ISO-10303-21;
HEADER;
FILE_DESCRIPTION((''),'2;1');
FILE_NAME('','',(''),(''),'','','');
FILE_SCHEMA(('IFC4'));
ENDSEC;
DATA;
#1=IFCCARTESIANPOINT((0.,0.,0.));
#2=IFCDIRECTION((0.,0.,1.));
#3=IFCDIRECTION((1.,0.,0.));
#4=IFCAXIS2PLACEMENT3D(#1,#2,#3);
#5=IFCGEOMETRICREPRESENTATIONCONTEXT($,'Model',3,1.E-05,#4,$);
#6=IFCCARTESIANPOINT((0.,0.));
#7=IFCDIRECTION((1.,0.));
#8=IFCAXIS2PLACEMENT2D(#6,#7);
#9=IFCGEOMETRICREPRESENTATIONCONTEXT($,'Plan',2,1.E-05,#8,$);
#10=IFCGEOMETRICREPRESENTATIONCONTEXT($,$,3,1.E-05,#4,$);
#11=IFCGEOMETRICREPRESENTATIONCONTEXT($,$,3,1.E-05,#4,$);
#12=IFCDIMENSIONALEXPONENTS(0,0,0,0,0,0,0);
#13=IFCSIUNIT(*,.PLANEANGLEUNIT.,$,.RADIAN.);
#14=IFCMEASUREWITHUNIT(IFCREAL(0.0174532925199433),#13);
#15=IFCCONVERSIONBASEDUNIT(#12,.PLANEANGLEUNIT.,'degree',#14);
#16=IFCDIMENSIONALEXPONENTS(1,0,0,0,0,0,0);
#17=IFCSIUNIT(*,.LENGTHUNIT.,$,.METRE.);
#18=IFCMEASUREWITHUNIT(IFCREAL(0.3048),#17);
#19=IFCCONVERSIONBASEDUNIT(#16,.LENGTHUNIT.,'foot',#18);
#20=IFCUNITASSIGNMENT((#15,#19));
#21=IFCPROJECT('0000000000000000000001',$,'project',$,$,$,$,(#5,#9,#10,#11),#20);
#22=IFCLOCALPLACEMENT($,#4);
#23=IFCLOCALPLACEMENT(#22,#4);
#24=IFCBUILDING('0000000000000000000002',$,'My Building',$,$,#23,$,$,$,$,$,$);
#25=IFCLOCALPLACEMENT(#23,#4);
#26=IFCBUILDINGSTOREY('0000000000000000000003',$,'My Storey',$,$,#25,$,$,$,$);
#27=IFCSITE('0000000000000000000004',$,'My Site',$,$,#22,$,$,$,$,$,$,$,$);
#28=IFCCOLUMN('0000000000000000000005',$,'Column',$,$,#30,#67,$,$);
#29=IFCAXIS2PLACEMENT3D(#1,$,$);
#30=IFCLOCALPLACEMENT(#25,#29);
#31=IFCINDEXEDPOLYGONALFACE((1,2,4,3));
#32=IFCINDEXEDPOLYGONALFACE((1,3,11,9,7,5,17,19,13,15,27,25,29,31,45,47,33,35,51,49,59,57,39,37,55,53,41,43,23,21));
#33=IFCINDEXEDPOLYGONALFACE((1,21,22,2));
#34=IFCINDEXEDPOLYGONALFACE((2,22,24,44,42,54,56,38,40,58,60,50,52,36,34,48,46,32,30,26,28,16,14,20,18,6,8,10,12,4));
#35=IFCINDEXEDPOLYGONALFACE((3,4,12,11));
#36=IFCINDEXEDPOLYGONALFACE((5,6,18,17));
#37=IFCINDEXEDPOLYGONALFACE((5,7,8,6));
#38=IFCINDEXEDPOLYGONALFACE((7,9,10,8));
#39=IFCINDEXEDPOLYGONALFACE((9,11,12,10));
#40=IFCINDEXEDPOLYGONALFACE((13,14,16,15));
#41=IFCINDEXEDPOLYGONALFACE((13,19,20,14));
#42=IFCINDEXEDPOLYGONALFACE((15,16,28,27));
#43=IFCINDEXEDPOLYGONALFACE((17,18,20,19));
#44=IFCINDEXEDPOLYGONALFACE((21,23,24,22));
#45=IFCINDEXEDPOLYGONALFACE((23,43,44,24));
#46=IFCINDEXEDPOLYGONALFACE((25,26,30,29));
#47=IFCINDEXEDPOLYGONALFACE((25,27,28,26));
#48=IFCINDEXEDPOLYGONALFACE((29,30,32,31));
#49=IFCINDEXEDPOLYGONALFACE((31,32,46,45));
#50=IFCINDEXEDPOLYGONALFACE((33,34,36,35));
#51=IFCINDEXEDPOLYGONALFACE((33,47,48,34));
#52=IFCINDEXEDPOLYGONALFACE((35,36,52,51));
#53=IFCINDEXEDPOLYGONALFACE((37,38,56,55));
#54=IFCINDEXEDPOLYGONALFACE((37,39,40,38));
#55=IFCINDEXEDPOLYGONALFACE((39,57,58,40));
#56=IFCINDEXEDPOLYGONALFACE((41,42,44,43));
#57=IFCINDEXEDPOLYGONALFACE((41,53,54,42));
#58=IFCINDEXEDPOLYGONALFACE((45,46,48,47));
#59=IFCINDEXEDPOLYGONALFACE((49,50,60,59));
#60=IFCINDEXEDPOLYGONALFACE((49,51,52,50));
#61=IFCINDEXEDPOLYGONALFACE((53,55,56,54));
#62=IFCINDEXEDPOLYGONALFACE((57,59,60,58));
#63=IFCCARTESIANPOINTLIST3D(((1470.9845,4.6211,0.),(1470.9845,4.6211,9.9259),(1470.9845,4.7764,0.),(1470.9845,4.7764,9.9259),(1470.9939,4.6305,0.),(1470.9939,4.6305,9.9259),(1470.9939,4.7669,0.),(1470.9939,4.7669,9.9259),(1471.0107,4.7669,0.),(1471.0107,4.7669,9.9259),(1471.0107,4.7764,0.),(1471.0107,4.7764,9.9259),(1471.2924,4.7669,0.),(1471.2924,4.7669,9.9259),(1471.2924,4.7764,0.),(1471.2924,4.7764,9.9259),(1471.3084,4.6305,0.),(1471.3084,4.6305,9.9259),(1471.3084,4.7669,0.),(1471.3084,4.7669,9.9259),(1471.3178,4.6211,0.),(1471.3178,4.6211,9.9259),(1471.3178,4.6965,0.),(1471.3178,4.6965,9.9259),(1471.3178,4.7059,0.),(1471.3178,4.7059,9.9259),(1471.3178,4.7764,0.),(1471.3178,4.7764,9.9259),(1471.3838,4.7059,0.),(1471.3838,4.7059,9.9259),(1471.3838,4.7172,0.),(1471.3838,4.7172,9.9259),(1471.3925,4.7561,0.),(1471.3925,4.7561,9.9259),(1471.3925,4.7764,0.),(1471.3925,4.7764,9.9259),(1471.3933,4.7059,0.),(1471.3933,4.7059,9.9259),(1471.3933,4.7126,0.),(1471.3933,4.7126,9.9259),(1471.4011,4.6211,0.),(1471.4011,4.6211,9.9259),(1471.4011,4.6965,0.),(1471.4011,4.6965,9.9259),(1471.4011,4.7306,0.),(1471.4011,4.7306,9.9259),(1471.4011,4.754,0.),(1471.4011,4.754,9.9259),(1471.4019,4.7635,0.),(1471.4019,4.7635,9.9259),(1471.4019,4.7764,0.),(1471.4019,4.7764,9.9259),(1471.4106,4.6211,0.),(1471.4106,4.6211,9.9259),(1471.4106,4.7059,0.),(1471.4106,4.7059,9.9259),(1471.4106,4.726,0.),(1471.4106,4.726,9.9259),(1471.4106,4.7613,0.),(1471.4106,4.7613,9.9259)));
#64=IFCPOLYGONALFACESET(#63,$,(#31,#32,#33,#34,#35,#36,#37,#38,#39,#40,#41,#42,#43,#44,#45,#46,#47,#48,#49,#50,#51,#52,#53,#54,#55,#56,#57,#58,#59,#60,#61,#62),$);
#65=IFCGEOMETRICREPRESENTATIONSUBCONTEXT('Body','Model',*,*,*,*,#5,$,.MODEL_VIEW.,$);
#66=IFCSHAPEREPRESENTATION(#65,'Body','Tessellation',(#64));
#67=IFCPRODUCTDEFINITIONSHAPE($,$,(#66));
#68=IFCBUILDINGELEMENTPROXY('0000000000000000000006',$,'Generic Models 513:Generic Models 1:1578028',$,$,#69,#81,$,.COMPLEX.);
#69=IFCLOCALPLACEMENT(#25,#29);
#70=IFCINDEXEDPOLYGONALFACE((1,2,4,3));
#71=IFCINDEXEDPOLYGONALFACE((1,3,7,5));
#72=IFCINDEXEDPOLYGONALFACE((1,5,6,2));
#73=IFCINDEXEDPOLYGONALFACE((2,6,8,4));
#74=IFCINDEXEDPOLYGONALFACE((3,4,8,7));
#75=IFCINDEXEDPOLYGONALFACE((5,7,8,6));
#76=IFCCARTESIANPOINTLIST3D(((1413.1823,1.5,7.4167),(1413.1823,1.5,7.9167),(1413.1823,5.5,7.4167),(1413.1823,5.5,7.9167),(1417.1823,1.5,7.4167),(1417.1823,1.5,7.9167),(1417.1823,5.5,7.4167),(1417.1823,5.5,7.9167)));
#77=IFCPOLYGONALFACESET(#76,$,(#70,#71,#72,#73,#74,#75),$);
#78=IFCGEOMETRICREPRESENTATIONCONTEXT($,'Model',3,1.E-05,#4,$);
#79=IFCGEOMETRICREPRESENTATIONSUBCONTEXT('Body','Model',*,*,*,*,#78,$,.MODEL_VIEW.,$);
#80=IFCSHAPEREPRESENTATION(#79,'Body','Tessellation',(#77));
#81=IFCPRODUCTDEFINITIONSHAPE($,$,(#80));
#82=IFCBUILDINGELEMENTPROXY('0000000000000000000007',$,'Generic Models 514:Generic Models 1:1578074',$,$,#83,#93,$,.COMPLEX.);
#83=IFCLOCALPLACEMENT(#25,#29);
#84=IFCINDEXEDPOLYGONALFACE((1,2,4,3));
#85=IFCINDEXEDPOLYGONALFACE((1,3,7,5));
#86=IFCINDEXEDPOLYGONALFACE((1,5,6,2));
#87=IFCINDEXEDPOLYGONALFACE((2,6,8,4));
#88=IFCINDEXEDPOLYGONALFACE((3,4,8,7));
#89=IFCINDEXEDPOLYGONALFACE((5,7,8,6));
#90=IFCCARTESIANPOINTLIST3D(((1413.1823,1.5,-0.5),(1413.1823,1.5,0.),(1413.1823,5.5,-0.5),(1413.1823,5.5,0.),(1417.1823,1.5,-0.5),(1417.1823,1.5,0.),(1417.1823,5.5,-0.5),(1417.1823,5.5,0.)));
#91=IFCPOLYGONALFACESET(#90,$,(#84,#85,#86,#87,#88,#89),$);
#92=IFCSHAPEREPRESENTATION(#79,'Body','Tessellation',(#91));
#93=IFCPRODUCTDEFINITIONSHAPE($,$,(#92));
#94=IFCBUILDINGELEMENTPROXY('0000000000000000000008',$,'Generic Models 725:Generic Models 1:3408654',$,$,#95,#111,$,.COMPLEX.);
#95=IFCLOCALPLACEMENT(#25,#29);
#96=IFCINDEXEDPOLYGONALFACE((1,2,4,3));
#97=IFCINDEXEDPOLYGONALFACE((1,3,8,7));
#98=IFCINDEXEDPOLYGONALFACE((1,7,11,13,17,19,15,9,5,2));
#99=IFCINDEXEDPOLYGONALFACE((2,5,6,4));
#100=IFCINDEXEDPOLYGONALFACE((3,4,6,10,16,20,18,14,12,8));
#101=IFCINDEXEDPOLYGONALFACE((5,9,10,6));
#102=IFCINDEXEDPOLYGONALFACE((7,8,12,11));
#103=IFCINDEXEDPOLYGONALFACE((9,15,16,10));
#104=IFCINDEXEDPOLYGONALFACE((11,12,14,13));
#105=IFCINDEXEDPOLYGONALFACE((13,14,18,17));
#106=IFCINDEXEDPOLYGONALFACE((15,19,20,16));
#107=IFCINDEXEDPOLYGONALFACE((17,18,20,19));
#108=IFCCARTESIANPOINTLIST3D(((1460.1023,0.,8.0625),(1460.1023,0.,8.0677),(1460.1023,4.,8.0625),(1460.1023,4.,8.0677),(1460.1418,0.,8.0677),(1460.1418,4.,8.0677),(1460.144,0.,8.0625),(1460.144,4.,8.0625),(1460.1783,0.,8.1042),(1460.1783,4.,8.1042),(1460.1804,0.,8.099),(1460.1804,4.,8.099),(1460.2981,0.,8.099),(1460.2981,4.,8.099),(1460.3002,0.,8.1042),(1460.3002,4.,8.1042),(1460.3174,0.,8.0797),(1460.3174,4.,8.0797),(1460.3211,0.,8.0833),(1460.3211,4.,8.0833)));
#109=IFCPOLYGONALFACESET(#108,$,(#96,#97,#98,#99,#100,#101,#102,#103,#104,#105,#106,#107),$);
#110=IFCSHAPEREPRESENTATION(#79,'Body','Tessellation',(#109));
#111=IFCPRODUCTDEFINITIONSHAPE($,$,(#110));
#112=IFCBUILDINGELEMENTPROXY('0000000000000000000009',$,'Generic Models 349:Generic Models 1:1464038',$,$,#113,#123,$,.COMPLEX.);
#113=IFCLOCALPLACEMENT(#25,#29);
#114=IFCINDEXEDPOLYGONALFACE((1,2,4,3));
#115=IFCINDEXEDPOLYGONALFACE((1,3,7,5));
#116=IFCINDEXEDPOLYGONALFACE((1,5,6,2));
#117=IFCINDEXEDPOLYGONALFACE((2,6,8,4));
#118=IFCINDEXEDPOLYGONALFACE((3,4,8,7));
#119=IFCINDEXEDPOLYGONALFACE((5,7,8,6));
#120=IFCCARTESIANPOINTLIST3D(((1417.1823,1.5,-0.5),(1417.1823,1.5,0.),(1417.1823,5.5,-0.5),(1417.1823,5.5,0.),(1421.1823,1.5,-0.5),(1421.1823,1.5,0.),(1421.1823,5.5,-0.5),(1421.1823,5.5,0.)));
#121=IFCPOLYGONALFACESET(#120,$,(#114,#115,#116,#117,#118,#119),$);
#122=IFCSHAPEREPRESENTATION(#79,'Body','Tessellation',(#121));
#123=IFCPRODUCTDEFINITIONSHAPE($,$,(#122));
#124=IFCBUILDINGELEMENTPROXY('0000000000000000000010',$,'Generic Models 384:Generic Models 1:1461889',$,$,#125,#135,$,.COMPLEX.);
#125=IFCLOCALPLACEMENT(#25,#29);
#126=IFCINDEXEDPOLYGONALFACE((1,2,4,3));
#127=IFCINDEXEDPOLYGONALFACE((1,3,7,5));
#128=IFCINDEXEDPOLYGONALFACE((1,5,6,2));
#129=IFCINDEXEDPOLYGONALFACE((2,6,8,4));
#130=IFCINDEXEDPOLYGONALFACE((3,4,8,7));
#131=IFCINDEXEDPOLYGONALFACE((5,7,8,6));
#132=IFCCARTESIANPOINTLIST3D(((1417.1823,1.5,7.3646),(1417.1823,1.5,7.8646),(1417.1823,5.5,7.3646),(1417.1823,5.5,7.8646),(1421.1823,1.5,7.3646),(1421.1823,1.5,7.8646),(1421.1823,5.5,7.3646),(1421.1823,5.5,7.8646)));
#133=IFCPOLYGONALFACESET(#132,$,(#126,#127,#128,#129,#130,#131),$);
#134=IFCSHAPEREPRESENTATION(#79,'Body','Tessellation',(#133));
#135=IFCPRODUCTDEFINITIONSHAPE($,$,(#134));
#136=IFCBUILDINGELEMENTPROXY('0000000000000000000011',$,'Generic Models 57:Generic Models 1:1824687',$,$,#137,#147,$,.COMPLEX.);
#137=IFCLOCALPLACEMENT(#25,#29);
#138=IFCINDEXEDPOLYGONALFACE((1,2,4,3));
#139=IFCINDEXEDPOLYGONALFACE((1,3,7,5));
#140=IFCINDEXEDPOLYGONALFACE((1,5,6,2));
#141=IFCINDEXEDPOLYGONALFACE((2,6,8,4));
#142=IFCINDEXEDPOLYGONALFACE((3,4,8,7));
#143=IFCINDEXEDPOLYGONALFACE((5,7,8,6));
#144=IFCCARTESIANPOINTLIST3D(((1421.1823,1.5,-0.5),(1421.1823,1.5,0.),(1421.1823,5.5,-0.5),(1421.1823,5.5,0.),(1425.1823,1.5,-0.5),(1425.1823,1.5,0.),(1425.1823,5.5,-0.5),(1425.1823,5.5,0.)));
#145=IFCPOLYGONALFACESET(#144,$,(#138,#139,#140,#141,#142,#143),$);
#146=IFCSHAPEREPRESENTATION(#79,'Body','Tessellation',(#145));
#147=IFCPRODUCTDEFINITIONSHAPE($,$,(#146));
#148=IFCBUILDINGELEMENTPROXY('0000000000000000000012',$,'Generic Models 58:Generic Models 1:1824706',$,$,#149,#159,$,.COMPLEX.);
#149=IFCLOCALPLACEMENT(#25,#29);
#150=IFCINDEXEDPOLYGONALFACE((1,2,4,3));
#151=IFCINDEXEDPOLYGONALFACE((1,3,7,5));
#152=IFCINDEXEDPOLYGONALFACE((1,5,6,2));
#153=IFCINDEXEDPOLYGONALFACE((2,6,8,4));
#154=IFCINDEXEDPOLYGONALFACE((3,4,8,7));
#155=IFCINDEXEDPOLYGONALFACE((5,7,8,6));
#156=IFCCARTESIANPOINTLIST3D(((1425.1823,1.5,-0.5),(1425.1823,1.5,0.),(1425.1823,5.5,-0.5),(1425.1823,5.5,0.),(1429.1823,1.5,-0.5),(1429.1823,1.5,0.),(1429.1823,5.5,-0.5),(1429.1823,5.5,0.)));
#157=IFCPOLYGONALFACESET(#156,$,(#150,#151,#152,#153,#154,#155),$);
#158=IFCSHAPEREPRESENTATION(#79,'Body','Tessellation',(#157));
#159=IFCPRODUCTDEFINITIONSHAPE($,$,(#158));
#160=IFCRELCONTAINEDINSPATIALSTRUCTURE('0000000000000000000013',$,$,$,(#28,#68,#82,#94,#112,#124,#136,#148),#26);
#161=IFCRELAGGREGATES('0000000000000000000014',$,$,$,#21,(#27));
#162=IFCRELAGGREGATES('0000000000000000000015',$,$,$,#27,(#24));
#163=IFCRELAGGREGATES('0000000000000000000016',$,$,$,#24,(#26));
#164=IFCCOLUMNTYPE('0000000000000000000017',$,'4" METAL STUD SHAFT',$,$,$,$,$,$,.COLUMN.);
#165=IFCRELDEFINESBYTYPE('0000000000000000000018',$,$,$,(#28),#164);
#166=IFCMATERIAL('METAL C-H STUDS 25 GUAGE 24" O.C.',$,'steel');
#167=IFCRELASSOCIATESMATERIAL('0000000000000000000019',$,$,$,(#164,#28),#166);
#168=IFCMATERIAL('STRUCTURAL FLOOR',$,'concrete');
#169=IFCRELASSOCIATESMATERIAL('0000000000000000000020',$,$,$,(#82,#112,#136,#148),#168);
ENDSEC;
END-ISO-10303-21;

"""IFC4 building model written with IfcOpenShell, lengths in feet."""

from ifc_helpers import new_model, entity, si_unit, converted_unit, frame, origin_with_axes, origin_2d_with_axis, place, context, subcontext, project, spatial, polyline, line, indexed_curve, outline, extrude, material, material_profile, profile_set, profile_usage, type_object, element, save


model = new_model("IFC4")

# Units and contexts
model_context_1 = context("Model", 3, precision=1e-05, world=origin_with_axes())
plan_context = context("Plan", 2, precision=1e-05, world=origin_2d_with_axis())
model_context_2 = context("Model", 3, precision=1e-05, world=origin_with_axes())
context_of_model_1 = context(None, 3, precision=1e-05, world=origin_with_axes())
context_of_model_2 = context(None, 3, precision=1e-05, world=origin_with_axes())
body_context_1 = subcontext(model_context_1, "Body", "Model", "MODEL_VIEW")
body_context_2 = subcontext(model_context_2, "Body", "Model", "MODEL_VIEW")
ifc_project = project(units=[converted_unit("PLANEANGLEUNIT", "degree", entity("IfcReal", 0.0174532925199433), si_unit("PLANEANGLEUNIT", "RADIAN"), dimensions=[0, 0, 0, 0, 0, 0, 0]), converted_unit("LENGTHUNIT", "foot", entity("IfcReal", 0.3048), si_unit("LENGTHUNIT", "METRE"), dimensions=[1, 0, 0, 0, 0, 0, 0])], contexts=[model_context_1, plan_context, context_of_model_1, context_of_model_2])

# Site, building, storey
site_placement = place(None, origin_with_axes())
site = spatial("IfcSite", under=ifc_project, at=site_placement, Name="My Site")
building_placement = place(site_placement, origin_with_axes())
building = spatial("IfcBuilding", under=site, at=building_placement, Name="My Building")
storey_placement = place(building_placement, origin_with_axes())
storey = spatial("IfcBuildingStorey", under=building, at=storey_placement, Name="My Storey")

# Column
ifc_material_1 = material(Name="METAL C-H STUDS 25 GUAGE 24\" O.C.", Category="steel")
ifc_material_profile = material_profile(ifc_material_1, outline(indexed_curve([(0.4088, 0.0849), (0.4261, 0.0849), (0.4261, 0.0), (0.4166, 0.0), (0.4166, 0.0754), (0.3333, 0.0754), (0.3333, 0.0), (0.0, 0.0), (0.0, 0.1553), (0.0262, 0.1553), (0.0262, 0.1459), (0.0094, 0.1459), (0.0094, 0.0094), (0.3239, 0.0094), (0.3239, 0.1459), (0.3079, 0.1459), (0.3079, 0.1553), (0.3333, 0.1553), (0.3333, 0.0848), (0.3993, 0.0849), (0.3993, 0.0961), (0.4166, 0.1095), (0.4166, 0.1329), (0.408, 0.1351), (0.408, 0.1553), (0.4174, 0.1553), (0.4174, 0.1424), (0.4261, 0.1403), (0.4261, 0.1049), (0.4088, 0.0915)], segments=[line(24, 23), line(23, 22), line(22, 21), line(21, 20), line(20, 19), line(19, 18), line(18, 17), line(17, 16), line(16, 15), line(15, 14), line(14, 13), line(13, 12), line(12, 11), line(11, 10), line(10, 9), line(9, 8), line(8, 7), line(7, 6), line(6, 5), line(5, 4), line(4, 3), line(3, 2), line(2, 1), line(1, 30), line(30, 29), line(29, 28), line(28, 27), line(27, 26), line(26, 25), line(25, 24)], self_intersect=False)))
ifc_profile_set = profile_set([ifc_material_profile])
ifc_profile_usage = profile_usage(ifc_profile_set)
column_type = type_object("IfcColumnType", Name="4\" METAL STUD SHAFT", PredefinedType="COLUMN", material=ifc_profile_set)
column_placement = place(storey_placement, frame((1470.9845, 4.6211, 0.0), z_axis=(0.0, 0.0, 1.0), x_axis=(1.0, 0.0, 0.0)))
element("IfcColumn", 1, at=column_placement, inside=storey, type_object=column_type, material=ifc_profile_usage, Name="Column", context=body_context_1, shape_type="SweptSolid", body=[
    extrude(outline(indexed_curve([(0.4088, 0.0849), (0.4261, 0.0849), (0.4261, 0.0), (0.4166, 0.0), (0.4166, 0.0754), (0.3333, 0.0754), (0.3333, 0.0), (0.0, 0.0), (0.0, 0.1553), (0.0262, 0.1553), (0.0262, 0.1459), (0.0094, 0.1459), (0.0094, 0.0094), (0.3239, 0.0094), (0.3239, 0.1459), (0.3079, 0.1459), (0.3079, 0.1553), (0.3333, 0.1553), (0.3333, 0.0848), (0.3993, 0.0849), (0.3993, 0.0961), (0.4166, 0.1095), (0.4166, 0.1329), (0.408, 0.1351), (0.408, 0.1553), (0.4174, 0.1553), (0.4174, 0.1424), (0.4261, 0.1403), (0.4261, 0.1049), (0.4088, 0.0915)], segments=[line(24, 23), line(23, 22), line(22, 21), line(21, 20), line(20, 19), line(19, 18), line(18, 17), line(17, 16), line(16, 15), line(15, 14), line(14, 13), line(13, 12), line(12, 11), line(11, 10), line(10, 9), line(9, 8), line(8, 7), line(7, 6), line(6, 5), line(5, 4), line(4, 3), line(3, 2), line(2, 1), line(1, 30), line(30, 29), line(29, 28), line(28, 27), line(27, 26), line(26, 25), line(25, 24)], self_intersect=False)), origin_with_axes(), (0.0, 0.0, 1.0), 9.9259),
])

# Building element proxies
proxy_1_placement = place(storey_placement, frame((1413.1823, 5.5, 7.4167), z_axis=(0.0, -1.0, 0.0), x_axis=(0.0, 0.0, 1.0)))
element("IfcBuildingElementProxy", 2, at=proxy_1_placement, inside=storey, Name="Generic Models 513:Generic Models 1:1578028", PredefinedType="COMPLEX", context=body_context_2, shape_type="SweptSolid", body=[
    extrude(outline(polyline([(-0.25, -2.0), (0.25, -2.0), (0.25, 2.0), (-0.25, 2.0), (-0.25, -2.0)])), frame((0.25, -2.0, 0.0), z_axis=(0.0, 0.0, -1.0), x_axis=(1.0, 0.0, 0.0)), (0.0, 0.0, -1.0), 4.0),
])
ifc_material_2 = material(Name="STRUCTURAL FLOOR", Category="concrete")
proxy_2_placement = place(storey_placement, frame((1413.1823, 5.5, -0.5), z_axis=(0.0, -1.0, 0.0), x_axis=(0.0, 0.0, 1.0)))
element("IfcBuildingElementProxy", 3, at=proxy_2_placement, inside=storey, material=ifc_material_2, Name="Generic Models 514:Generic Models 1:1578074", PredefinedType="COMPLEX", context=body_context_2, shape_type="SweptSolid", body=[
    extrude(outline(polyline([(-0.25, -2.0), (0.25, -2.0), (0.25, 2.0), (-0.25, 2.0), (-0.25, -2.0)])), frame((0.25, -2.0, 0.0), z_axis=(0.0, 0.0, -1.0), x_axis=(1.0, 0.0, 0.0)), (0.0, 0.0, -1.0), 4.0),
])
proxy_3_placement = place(storey_placement, frame((1460.1023, 4.0, 8.0625), z_axis=(0.0, -1.0, 0.0), x_axis=(0.0, 0.0, 1.0)))
element("IfcBuildingElementProxy", 4, at=proxy_3_placement, inside=storey, Name="Generic Models 725:Generic Models 1:3408654", PredefinedType="COMPLEX", context=body_context_2, shape_type="SweptSolid", body=[
    extrude(outline(polyline([(0.1082, 0.0), (0.1072, 0.0051), (0.0684, -0.0024), (0.0258, 0.0266), (-0.094, 0.0035), (-0.1105, -0.0209), (-0.1062, -0.0238), (-0.0909, -0.0012), (0.0246, 0.021), (0.0673, -0.0079), (0.1082, 0.0)])), frame((0.0205, -0.1063, 0.0), z_axis=(0.0, 0.0, -1.0), x_axis=(-0.189091, 0.98196, 0.0)), (0.0, 0.0, -1.0), 4.0),
])
proxy_4_placement = place(storey_placement, frame((1417.1823, 5.5, -0.5), z_axis=(0.0, -1.0, 0.0), x_axis=(0.0, 0.0, 1.0)))
element("IfcBuildingElementProxy", 5, at=proxy_4_placement, inside=storey, material=ifc_material_2, Name="Generic Models 349:Generic Models 1:1464038", PredefinedType="COMPLEX", context=body_context_2, shape_type="SweptSolid", body=[
    extrude(outline(polyline([(-0.25, -2.0), (0.25, -2.0), (0.25, 2.0), (-0.25, 2.0), (-0.25, -2.0)])), frame((0.25, -2.0, 0.0), z_axis=(0.0, 0.0, -1.0), x_axis=(1.0, 0.0, 0.0)), (0.0, 0.0, -1.0), 4.0),
])
proxy_5_placement = place(storey_placement, frame((1417.1823, 5.5, 7.3646), z_axis=(0.0, -1.0, 0.0), x_axis=(0.0, 0.0, 1.0)))
element("IfcBuildingElementProxy", 6, at=proxy_5_placement, inside=storey, Name="Generic Models 384:Generic Models 1:1461889", PredefinedType="COMPLEX", context=body_context_2, shape_type="SweptSolid", body=[
    extrude(outline(polyline([(-0.25, -2.0), (0.25, -2.0), (0.25, 2.0), (-0.25, 2.0), (-0.25, -2.0)])), frame((0.25, -2.0, 0.0), z_axis=(0.0, 0.0, -1.0), x_axis=(1.0, 0.0, 0.0)), (0.0, 0.0, -1.0), 4.0),
])
for number, where, z_axis, x_axis, name in (
    (7, (1421.1823, 5.5, -0.5), (0.0, -1.0, 0.0), (0.0, 0.0, 1.0), "Generic Models 57:Generic Models 1:1824687"),
    (8, (1425.1823, 5.5, -0.5), (0.0, -1.0, 0.0), (0.0, 0.0, 1.0), "Generic Models 58:Generic Models 1:1824706"),
):
    element("IfcBuildingElementProxy", number, at=place(storey_placement, frame(where, z_axis=z_axis, x_axis=x_axis)), inside=storey, material=ifc_material_2, Name=name, PredefinedType="COMPLEX", context=body_context_2, shape_type="SweptSolid", body=[
        extrude(outline(polyline([(-0.25, -2.0), (0.25, -2.0), (0.25, 2.0), (-0.25, 2.0), (-0.25, -2.0)])), frame((0.25, -2.0, 0.0), z_axis=(0.0, 0.0, -1.0), x_axis=(1.0, 0.0, 0.0)), (0.0, 0.0, -1.0), 4.0),
    ])

save(model, "model.ifc")
